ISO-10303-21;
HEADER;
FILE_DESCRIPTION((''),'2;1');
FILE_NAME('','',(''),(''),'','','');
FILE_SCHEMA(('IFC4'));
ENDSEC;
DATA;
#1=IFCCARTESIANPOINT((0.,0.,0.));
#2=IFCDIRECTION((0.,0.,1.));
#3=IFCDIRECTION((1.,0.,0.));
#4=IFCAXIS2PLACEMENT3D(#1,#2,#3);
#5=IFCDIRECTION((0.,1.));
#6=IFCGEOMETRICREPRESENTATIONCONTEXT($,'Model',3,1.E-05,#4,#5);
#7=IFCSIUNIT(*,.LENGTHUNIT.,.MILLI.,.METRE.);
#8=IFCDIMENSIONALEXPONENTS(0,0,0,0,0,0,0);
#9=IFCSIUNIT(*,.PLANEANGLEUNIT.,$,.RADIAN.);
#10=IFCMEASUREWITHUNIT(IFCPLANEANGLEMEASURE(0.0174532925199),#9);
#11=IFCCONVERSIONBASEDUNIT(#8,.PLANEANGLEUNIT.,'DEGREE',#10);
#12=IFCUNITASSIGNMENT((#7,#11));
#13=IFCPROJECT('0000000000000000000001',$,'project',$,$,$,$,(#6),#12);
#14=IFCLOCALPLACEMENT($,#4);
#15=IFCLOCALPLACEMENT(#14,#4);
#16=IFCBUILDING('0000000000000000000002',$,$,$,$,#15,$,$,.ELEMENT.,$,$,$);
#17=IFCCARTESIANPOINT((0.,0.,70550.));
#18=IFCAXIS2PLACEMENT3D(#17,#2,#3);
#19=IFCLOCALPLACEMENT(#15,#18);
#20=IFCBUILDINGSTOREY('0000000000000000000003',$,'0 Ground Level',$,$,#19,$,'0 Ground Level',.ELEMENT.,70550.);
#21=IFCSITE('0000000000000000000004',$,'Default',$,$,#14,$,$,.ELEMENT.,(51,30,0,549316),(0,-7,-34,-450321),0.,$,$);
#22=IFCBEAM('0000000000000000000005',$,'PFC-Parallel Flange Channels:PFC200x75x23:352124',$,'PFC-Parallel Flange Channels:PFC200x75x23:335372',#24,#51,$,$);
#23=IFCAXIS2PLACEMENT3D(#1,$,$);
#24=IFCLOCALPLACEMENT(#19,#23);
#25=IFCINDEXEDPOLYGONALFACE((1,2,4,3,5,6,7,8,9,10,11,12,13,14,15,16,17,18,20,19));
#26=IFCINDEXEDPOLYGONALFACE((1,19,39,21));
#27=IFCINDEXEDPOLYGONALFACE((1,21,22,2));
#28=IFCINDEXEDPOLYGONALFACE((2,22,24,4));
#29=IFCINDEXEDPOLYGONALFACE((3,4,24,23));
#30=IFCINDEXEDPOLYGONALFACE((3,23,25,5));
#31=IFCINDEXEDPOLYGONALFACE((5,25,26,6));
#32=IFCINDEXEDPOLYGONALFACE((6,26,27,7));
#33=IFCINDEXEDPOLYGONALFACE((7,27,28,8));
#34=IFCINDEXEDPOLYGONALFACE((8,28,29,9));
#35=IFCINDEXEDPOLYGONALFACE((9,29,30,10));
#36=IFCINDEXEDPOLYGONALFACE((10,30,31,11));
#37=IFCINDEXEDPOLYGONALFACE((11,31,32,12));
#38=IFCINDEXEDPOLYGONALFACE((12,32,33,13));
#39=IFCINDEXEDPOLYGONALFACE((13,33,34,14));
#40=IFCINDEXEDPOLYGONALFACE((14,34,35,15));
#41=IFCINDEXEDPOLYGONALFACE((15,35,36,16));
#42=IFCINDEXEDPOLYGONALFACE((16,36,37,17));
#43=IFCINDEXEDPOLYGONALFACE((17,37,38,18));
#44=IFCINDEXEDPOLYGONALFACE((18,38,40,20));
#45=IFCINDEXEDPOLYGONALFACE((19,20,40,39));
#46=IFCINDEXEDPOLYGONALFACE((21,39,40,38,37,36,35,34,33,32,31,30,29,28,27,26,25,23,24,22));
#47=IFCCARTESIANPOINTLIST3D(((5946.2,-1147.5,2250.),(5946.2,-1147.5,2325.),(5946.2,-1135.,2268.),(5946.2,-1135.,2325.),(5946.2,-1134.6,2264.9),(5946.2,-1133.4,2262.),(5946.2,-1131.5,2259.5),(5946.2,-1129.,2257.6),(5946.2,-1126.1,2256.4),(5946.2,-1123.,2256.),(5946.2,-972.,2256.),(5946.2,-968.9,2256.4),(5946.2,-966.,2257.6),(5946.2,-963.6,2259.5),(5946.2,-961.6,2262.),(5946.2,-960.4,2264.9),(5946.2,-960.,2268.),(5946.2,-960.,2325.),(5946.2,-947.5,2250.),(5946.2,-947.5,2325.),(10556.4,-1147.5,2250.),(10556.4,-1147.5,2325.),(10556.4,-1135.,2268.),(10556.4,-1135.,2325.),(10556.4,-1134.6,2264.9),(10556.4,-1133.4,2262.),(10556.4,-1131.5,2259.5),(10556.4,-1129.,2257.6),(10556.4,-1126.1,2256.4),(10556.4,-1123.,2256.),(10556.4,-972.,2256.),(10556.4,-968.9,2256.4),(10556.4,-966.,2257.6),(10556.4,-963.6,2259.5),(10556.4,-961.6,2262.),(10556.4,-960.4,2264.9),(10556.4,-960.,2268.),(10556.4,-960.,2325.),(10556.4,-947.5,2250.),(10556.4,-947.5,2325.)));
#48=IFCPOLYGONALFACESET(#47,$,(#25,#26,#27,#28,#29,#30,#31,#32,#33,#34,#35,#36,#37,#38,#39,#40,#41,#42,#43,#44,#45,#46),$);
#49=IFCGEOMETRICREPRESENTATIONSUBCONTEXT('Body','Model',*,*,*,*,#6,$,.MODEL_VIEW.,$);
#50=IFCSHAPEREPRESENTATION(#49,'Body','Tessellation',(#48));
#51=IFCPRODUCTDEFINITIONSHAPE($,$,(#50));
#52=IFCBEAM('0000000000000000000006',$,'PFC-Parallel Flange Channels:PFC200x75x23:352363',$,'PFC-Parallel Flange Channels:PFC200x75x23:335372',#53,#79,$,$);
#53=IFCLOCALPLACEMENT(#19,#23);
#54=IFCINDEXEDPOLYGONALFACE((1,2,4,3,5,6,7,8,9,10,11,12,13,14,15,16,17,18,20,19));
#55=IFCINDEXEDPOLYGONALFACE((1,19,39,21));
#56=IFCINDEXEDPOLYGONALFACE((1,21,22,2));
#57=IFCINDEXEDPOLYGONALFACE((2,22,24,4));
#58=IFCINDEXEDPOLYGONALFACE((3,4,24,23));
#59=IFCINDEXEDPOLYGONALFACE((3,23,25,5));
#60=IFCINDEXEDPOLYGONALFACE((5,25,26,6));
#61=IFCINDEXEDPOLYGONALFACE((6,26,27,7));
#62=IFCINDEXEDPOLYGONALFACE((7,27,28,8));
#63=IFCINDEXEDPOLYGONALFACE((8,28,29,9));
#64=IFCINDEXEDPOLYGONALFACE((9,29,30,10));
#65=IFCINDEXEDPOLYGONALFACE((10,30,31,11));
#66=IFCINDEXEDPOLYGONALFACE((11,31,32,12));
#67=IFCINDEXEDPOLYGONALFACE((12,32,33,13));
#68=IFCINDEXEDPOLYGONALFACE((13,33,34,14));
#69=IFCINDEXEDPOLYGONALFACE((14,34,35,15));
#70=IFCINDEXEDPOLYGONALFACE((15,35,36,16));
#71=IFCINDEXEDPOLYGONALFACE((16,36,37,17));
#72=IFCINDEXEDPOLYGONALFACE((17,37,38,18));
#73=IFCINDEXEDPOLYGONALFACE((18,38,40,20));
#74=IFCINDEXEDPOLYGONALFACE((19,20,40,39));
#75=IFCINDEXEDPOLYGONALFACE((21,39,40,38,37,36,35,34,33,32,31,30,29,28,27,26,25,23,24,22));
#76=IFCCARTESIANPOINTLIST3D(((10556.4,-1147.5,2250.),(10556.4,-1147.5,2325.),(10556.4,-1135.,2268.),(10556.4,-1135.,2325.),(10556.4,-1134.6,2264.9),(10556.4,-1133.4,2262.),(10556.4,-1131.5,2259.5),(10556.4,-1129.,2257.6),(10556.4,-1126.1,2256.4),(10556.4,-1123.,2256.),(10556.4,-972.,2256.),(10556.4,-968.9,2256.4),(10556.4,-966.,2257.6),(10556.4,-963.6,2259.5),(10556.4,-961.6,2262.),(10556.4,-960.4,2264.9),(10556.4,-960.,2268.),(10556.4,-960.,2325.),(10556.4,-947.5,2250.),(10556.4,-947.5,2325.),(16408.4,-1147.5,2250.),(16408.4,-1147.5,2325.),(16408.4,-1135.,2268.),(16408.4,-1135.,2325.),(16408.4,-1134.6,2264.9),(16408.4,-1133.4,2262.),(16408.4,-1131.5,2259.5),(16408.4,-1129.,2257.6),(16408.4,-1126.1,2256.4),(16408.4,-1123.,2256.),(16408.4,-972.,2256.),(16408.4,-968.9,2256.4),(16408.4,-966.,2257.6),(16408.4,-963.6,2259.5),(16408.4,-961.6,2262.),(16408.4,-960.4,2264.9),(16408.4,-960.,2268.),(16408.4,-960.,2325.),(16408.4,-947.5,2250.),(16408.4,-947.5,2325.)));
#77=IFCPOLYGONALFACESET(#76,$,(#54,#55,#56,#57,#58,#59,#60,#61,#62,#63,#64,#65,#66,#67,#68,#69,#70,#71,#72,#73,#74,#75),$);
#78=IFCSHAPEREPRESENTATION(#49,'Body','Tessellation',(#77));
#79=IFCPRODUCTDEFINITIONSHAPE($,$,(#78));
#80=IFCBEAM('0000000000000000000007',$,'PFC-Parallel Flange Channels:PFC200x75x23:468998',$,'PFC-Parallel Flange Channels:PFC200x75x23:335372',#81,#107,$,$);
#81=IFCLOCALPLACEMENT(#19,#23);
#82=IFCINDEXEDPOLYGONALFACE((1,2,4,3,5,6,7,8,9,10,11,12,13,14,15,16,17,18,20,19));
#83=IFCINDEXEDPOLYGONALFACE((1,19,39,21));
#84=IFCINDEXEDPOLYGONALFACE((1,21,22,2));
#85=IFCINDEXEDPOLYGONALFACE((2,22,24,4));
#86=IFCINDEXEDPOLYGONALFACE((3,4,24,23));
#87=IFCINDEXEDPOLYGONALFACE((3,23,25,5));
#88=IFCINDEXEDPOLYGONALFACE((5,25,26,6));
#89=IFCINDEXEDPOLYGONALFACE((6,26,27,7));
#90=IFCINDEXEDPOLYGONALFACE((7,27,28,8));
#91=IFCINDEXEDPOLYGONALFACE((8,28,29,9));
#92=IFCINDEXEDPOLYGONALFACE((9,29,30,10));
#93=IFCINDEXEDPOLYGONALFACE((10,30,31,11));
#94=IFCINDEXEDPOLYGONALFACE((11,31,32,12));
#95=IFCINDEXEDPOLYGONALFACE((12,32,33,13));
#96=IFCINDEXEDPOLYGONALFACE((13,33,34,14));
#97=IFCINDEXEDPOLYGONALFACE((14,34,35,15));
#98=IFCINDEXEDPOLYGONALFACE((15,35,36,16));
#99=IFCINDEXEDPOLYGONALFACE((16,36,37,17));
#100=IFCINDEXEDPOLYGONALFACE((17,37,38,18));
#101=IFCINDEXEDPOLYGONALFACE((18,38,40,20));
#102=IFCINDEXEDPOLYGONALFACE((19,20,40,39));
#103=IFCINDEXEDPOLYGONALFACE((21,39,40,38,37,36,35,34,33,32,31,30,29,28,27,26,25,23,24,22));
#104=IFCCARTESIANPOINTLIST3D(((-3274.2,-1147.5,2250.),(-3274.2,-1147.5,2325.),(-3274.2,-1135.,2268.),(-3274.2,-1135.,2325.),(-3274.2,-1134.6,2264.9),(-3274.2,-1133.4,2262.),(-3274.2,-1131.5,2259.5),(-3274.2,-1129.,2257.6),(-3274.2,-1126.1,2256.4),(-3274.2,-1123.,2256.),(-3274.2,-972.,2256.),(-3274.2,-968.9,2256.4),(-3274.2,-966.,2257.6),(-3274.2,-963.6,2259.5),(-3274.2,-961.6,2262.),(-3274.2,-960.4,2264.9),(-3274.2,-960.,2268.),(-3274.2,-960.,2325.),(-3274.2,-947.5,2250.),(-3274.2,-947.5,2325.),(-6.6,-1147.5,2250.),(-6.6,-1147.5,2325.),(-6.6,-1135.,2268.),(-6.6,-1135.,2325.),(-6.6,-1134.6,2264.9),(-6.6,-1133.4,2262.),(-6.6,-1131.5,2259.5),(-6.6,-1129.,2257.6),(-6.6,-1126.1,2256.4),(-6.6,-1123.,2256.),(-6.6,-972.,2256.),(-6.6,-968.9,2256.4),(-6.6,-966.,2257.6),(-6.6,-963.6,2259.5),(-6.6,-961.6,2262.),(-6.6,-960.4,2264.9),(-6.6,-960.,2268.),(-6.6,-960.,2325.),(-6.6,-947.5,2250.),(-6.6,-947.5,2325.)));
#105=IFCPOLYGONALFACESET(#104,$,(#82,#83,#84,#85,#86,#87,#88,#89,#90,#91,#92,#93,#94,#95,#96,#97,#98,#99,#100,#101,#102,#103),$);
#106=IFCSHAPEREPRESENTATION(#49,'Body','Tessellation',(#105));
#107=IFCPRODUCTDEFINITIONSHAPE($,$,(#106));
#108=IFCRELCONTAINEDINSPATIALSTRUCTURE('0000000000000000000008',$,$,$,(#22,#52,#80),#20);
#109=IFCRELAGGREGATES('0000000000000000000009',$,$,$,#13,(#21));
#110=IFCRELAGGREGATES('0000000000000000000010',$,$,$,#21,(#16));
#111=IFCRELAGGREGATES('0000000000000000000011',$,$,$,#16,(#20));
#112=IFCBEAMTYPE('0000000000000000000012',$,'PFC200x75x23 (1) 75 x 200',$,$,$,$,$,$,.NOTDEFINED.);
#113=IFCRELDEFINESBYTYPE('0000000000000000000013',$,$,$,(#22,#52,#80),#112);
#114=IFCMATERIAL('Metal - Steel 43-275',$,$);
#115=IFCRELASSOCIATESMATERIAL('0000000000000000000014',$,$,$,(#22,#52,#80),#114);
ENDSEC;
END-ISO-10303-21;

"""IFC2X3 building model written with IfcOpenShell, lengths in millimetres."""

from ifc_helpers import new_model, entity, si_unit, converted_unit, point, direction, frame, frame_2d, origin_with_axes, place, context, subcontext, project, spatial, polyline, circle_curve, parameter, trimmed, segment, composite_curve, outline, extrude, material, type_object, element, save


model = new_model("IFC2X3")

# Units and contexts
model_context = context("Model", 3, precision=1e-05, world=origin_with_axes(), true_north=direction((0.0, 1.0)))
body_context = subcontext(model_context, "Body", "Model", "MODEL_VIEW")
ifc_project = project(units=[si_unit("LENGTHUNIT", "METRE", prefix="MILLI"), converted_unit("PLANEANGLEUNIT", "DEGREE", entity("IfcPlaneAngleMeasure", 0.0174532925199), si_unit("PLANEANGLEUNIT", "RADIAN"), dimensions=[0, 0, 0, 0, 0, 0, 0])], contexts=[model_context])

# Site, building, storey
site_placement = place(None, origin_with_axes())
site = spatial("IfcSite", under=ifc_project, at=site_placement, Name="Default", CompositionType="ELEMENT", RefLatitude=(51, 30, 0, 549316), RefLongitude=(0, -7, -34, -450321), RefElevation=0.0)
building_placement = place(site_placement, origin_with_axes())
building = spatial("IfcBuilding", under=site, at=building_placement, CompositionType="ELEMENT")
storey_placement = place(building_placement, frame((0.0, 0.0, 70550.0), z_axis=(0.0, 0.0, 1.0), x_axis=(1.0, 0.0, 0.0)))
storey = spatial("IfcBuildingStorey", under=building, at=storey_placement, Name="0 Ground Level", LongName="0 Ground Level", CompositionType="ELEMENT", Elevation=70550.0)

# Beams
ifc_material = material(Name="Metal - Steel 43-275")
beam_type_1 = type_object("IfcBeamType", Name="PFC200x75x23 (1) 75 x 200", PredefinedType="NOTDEFINED")
beam_1_placement = place(storey_placement, frame((10556.4, -1047.5, 2284.8), z_axis=(0.0, 0.0, 1.0), x_axis=(0.0, 1.0, 0.0)))
element("IfcBeam", 1, at=beam_1_placement, inside=storey, type_object=beam_type_1, material=ifc_material, Name="PFC-Parallel Flange Channels:PFC200x75x23:352124", ObjectType="PFC-Parallel Flange Channels:PFC200x75x23:335372", context=body_context, shape_type="SweptSolid", body=[
    extrude(outline(composite_curve([segment(polyline([(-40.2, -100.0), (34.8, -100.0), (34.8, 100.0), (-40.2, 100.0), (-40.2, 87.5), (16.8, 87.5)]), True, "CONTINUOUS"), segment(trimmed(circle_curve(frame_2d((16.8, 75.5), x_axis=(1.0, 0.0)), 12.0), [point((16.8, 87.5)), parameter(90.0)], [point((28.8, 75.5)), parameter(0.0)], False, "CARTESIAN"), True, "CONTINUOUS"), segment(polyline([(28.8, 75.5), (28.8, -75.5)]), True, "CONTINUOUS"), segment(trimmed(circle_curve(frame_2d((16.8, -75.5), x_axis=(0.0, -1.0)), 12.0), [point((28.8, -75.5)), parameter(90.0)], [point((16.8, -87.5)), parameter(0.0)], False, "CARTESIAN"), True, "CONTINUOUS"), segment(polyline([(16.8, -87.5), (-40.2, -87.5), (-40.2, -100.0)]), True, "CONTINUOUS")], self_intersect=False)), frame((0.0, 4610.2, 0.0), z_axis=(0.0, -1.0, 0.0), x_axis=(0.0, 0.0, -1.0)), (0.0, 0.0, 1.0), 4610.2),
])
beam_2_placement = place(storey_placement, frame((16408.4, -1047.5, 2284.8), z_axis=(0.0, 0.0, 1.0), x_axis=(0.0, 1.0, 0.0)))
element("IfcBeam", 2, at=beam_2_placement, inside=storey, type_object=beam_type_1, material=ifc_material, Name="PFC-Parallel Flange Channels:PFC200x75x23:352363", ObjectType="PFC-Parallel Flange Channels:PFC200x75x23:335372", context=body_context, shape_type="SweptSolid", body=[
    extrude(outline(composite_curve([segment(polyline([(-40.2, -100.0), (34.8, -100.0), (34.8, 100.0), (-40.2, 100.0), (-40.2, 87.5), (16.8, 87.5)]), True, "CONTINUOUS"), segment(trimmed(circle_curve(frame_2d((16.8, 75.5), x_axis=(1.0, 0.0)), 12.0), [point((16.8, 87.5)), parameter(90.0)], [point((28.8, 75.5)), parameter(0.0)], False, "CARTESIAN"), True, "CONTINUOUS"), segment(polyline([(28.8, 75.5), (28.8, -75.5)]), True, "CONTINUOUS"), segment(trimmed(circle_curve(frame_2d((16.8, -75.5), x_axis=(0.0, -1.0)), 12.0), [point((28.8, -75.5)), parameter(90.0)], [point((16.8, -87.5)), parameter(0.0)], False, "CARTESIAN"), True, "CONTINUOUS"), segment(polyline([(16.8, -87.5), (-40.2, -87.5), (-40.2, -100.0)]), True, "CONTINUOUS")], self_intersect=False)), frame((0.0, 5852.0, 0.0), z_axis=(0.0, -1.0, 0.0), x_axis=(0.0, 0.0, -1.0)), (0.0, 0.0, 1.0), 5852.0),
])
beam_3_placement = place(storey_placement, frame((-6.6, -1047.5, 2284.8), z_axis=(0.0, 0.0, 1.0), x_axis=(0.0, 1.0, 0.0)))
element("IfcBeam", 3, at=beam_3_placement, inside=storey, type_object=beam_type_1, material=ifc_material, Name="PFC-Parallel Flange Channels:PFC200x75x23:468998", ObjectType="PFC-Parallel Flange Channels:PFC200x75x23:335372", context=body_context, shape_type="SweptSolid", body=[
    extrude(outline(composite_curve([segment(polyline([(-40.2, -100.0), (34.8, -100.0), (34.8, 100.0), (-40.2, 100.0), (-40.2, 87.5), (16.8, 87.5)]), True, "CONTINUOUS"), segment(trimmed(circle_curve(frame_2d((16.8, 75.5), x_axis=(1.0, 0.0)), 12.0), [point((16.8, 87.5)), parameter(90.0)], [point((28.8, 75.5)), parameter(0.0)], False, "CARTESIAN"), True, "CONTINUOUS"), segment(polyline([(28.8, 75.5), (28.8, -75.5)]), True, "CONTINUOUS"), segment(trimmed(circle_curve(frame_2d((16.8, -75.5), x_axis=(0.0, -1.0)), 12.0), [point((28.8, -75.5)), parameter(90.0)], [point((16.8, -87.5)), parameter(0.0)], False, "CARTESIAN"), True, "CONTINUOUS"), segment(polyline([(16.8, -87.5), (-40.2, -87.5), (-40.2, -100.0)]), True, "CONTINUOUS")], self_intersect=False)), frame((0.0, 3267.6, 0.0), z_axis=(0.0, -1.0, 0.0), x_axis=(0.0, 0.0, -1.0)), (0.0, 0.0, 1.0), 3267.6),
])

save(model, "model.ifc")
